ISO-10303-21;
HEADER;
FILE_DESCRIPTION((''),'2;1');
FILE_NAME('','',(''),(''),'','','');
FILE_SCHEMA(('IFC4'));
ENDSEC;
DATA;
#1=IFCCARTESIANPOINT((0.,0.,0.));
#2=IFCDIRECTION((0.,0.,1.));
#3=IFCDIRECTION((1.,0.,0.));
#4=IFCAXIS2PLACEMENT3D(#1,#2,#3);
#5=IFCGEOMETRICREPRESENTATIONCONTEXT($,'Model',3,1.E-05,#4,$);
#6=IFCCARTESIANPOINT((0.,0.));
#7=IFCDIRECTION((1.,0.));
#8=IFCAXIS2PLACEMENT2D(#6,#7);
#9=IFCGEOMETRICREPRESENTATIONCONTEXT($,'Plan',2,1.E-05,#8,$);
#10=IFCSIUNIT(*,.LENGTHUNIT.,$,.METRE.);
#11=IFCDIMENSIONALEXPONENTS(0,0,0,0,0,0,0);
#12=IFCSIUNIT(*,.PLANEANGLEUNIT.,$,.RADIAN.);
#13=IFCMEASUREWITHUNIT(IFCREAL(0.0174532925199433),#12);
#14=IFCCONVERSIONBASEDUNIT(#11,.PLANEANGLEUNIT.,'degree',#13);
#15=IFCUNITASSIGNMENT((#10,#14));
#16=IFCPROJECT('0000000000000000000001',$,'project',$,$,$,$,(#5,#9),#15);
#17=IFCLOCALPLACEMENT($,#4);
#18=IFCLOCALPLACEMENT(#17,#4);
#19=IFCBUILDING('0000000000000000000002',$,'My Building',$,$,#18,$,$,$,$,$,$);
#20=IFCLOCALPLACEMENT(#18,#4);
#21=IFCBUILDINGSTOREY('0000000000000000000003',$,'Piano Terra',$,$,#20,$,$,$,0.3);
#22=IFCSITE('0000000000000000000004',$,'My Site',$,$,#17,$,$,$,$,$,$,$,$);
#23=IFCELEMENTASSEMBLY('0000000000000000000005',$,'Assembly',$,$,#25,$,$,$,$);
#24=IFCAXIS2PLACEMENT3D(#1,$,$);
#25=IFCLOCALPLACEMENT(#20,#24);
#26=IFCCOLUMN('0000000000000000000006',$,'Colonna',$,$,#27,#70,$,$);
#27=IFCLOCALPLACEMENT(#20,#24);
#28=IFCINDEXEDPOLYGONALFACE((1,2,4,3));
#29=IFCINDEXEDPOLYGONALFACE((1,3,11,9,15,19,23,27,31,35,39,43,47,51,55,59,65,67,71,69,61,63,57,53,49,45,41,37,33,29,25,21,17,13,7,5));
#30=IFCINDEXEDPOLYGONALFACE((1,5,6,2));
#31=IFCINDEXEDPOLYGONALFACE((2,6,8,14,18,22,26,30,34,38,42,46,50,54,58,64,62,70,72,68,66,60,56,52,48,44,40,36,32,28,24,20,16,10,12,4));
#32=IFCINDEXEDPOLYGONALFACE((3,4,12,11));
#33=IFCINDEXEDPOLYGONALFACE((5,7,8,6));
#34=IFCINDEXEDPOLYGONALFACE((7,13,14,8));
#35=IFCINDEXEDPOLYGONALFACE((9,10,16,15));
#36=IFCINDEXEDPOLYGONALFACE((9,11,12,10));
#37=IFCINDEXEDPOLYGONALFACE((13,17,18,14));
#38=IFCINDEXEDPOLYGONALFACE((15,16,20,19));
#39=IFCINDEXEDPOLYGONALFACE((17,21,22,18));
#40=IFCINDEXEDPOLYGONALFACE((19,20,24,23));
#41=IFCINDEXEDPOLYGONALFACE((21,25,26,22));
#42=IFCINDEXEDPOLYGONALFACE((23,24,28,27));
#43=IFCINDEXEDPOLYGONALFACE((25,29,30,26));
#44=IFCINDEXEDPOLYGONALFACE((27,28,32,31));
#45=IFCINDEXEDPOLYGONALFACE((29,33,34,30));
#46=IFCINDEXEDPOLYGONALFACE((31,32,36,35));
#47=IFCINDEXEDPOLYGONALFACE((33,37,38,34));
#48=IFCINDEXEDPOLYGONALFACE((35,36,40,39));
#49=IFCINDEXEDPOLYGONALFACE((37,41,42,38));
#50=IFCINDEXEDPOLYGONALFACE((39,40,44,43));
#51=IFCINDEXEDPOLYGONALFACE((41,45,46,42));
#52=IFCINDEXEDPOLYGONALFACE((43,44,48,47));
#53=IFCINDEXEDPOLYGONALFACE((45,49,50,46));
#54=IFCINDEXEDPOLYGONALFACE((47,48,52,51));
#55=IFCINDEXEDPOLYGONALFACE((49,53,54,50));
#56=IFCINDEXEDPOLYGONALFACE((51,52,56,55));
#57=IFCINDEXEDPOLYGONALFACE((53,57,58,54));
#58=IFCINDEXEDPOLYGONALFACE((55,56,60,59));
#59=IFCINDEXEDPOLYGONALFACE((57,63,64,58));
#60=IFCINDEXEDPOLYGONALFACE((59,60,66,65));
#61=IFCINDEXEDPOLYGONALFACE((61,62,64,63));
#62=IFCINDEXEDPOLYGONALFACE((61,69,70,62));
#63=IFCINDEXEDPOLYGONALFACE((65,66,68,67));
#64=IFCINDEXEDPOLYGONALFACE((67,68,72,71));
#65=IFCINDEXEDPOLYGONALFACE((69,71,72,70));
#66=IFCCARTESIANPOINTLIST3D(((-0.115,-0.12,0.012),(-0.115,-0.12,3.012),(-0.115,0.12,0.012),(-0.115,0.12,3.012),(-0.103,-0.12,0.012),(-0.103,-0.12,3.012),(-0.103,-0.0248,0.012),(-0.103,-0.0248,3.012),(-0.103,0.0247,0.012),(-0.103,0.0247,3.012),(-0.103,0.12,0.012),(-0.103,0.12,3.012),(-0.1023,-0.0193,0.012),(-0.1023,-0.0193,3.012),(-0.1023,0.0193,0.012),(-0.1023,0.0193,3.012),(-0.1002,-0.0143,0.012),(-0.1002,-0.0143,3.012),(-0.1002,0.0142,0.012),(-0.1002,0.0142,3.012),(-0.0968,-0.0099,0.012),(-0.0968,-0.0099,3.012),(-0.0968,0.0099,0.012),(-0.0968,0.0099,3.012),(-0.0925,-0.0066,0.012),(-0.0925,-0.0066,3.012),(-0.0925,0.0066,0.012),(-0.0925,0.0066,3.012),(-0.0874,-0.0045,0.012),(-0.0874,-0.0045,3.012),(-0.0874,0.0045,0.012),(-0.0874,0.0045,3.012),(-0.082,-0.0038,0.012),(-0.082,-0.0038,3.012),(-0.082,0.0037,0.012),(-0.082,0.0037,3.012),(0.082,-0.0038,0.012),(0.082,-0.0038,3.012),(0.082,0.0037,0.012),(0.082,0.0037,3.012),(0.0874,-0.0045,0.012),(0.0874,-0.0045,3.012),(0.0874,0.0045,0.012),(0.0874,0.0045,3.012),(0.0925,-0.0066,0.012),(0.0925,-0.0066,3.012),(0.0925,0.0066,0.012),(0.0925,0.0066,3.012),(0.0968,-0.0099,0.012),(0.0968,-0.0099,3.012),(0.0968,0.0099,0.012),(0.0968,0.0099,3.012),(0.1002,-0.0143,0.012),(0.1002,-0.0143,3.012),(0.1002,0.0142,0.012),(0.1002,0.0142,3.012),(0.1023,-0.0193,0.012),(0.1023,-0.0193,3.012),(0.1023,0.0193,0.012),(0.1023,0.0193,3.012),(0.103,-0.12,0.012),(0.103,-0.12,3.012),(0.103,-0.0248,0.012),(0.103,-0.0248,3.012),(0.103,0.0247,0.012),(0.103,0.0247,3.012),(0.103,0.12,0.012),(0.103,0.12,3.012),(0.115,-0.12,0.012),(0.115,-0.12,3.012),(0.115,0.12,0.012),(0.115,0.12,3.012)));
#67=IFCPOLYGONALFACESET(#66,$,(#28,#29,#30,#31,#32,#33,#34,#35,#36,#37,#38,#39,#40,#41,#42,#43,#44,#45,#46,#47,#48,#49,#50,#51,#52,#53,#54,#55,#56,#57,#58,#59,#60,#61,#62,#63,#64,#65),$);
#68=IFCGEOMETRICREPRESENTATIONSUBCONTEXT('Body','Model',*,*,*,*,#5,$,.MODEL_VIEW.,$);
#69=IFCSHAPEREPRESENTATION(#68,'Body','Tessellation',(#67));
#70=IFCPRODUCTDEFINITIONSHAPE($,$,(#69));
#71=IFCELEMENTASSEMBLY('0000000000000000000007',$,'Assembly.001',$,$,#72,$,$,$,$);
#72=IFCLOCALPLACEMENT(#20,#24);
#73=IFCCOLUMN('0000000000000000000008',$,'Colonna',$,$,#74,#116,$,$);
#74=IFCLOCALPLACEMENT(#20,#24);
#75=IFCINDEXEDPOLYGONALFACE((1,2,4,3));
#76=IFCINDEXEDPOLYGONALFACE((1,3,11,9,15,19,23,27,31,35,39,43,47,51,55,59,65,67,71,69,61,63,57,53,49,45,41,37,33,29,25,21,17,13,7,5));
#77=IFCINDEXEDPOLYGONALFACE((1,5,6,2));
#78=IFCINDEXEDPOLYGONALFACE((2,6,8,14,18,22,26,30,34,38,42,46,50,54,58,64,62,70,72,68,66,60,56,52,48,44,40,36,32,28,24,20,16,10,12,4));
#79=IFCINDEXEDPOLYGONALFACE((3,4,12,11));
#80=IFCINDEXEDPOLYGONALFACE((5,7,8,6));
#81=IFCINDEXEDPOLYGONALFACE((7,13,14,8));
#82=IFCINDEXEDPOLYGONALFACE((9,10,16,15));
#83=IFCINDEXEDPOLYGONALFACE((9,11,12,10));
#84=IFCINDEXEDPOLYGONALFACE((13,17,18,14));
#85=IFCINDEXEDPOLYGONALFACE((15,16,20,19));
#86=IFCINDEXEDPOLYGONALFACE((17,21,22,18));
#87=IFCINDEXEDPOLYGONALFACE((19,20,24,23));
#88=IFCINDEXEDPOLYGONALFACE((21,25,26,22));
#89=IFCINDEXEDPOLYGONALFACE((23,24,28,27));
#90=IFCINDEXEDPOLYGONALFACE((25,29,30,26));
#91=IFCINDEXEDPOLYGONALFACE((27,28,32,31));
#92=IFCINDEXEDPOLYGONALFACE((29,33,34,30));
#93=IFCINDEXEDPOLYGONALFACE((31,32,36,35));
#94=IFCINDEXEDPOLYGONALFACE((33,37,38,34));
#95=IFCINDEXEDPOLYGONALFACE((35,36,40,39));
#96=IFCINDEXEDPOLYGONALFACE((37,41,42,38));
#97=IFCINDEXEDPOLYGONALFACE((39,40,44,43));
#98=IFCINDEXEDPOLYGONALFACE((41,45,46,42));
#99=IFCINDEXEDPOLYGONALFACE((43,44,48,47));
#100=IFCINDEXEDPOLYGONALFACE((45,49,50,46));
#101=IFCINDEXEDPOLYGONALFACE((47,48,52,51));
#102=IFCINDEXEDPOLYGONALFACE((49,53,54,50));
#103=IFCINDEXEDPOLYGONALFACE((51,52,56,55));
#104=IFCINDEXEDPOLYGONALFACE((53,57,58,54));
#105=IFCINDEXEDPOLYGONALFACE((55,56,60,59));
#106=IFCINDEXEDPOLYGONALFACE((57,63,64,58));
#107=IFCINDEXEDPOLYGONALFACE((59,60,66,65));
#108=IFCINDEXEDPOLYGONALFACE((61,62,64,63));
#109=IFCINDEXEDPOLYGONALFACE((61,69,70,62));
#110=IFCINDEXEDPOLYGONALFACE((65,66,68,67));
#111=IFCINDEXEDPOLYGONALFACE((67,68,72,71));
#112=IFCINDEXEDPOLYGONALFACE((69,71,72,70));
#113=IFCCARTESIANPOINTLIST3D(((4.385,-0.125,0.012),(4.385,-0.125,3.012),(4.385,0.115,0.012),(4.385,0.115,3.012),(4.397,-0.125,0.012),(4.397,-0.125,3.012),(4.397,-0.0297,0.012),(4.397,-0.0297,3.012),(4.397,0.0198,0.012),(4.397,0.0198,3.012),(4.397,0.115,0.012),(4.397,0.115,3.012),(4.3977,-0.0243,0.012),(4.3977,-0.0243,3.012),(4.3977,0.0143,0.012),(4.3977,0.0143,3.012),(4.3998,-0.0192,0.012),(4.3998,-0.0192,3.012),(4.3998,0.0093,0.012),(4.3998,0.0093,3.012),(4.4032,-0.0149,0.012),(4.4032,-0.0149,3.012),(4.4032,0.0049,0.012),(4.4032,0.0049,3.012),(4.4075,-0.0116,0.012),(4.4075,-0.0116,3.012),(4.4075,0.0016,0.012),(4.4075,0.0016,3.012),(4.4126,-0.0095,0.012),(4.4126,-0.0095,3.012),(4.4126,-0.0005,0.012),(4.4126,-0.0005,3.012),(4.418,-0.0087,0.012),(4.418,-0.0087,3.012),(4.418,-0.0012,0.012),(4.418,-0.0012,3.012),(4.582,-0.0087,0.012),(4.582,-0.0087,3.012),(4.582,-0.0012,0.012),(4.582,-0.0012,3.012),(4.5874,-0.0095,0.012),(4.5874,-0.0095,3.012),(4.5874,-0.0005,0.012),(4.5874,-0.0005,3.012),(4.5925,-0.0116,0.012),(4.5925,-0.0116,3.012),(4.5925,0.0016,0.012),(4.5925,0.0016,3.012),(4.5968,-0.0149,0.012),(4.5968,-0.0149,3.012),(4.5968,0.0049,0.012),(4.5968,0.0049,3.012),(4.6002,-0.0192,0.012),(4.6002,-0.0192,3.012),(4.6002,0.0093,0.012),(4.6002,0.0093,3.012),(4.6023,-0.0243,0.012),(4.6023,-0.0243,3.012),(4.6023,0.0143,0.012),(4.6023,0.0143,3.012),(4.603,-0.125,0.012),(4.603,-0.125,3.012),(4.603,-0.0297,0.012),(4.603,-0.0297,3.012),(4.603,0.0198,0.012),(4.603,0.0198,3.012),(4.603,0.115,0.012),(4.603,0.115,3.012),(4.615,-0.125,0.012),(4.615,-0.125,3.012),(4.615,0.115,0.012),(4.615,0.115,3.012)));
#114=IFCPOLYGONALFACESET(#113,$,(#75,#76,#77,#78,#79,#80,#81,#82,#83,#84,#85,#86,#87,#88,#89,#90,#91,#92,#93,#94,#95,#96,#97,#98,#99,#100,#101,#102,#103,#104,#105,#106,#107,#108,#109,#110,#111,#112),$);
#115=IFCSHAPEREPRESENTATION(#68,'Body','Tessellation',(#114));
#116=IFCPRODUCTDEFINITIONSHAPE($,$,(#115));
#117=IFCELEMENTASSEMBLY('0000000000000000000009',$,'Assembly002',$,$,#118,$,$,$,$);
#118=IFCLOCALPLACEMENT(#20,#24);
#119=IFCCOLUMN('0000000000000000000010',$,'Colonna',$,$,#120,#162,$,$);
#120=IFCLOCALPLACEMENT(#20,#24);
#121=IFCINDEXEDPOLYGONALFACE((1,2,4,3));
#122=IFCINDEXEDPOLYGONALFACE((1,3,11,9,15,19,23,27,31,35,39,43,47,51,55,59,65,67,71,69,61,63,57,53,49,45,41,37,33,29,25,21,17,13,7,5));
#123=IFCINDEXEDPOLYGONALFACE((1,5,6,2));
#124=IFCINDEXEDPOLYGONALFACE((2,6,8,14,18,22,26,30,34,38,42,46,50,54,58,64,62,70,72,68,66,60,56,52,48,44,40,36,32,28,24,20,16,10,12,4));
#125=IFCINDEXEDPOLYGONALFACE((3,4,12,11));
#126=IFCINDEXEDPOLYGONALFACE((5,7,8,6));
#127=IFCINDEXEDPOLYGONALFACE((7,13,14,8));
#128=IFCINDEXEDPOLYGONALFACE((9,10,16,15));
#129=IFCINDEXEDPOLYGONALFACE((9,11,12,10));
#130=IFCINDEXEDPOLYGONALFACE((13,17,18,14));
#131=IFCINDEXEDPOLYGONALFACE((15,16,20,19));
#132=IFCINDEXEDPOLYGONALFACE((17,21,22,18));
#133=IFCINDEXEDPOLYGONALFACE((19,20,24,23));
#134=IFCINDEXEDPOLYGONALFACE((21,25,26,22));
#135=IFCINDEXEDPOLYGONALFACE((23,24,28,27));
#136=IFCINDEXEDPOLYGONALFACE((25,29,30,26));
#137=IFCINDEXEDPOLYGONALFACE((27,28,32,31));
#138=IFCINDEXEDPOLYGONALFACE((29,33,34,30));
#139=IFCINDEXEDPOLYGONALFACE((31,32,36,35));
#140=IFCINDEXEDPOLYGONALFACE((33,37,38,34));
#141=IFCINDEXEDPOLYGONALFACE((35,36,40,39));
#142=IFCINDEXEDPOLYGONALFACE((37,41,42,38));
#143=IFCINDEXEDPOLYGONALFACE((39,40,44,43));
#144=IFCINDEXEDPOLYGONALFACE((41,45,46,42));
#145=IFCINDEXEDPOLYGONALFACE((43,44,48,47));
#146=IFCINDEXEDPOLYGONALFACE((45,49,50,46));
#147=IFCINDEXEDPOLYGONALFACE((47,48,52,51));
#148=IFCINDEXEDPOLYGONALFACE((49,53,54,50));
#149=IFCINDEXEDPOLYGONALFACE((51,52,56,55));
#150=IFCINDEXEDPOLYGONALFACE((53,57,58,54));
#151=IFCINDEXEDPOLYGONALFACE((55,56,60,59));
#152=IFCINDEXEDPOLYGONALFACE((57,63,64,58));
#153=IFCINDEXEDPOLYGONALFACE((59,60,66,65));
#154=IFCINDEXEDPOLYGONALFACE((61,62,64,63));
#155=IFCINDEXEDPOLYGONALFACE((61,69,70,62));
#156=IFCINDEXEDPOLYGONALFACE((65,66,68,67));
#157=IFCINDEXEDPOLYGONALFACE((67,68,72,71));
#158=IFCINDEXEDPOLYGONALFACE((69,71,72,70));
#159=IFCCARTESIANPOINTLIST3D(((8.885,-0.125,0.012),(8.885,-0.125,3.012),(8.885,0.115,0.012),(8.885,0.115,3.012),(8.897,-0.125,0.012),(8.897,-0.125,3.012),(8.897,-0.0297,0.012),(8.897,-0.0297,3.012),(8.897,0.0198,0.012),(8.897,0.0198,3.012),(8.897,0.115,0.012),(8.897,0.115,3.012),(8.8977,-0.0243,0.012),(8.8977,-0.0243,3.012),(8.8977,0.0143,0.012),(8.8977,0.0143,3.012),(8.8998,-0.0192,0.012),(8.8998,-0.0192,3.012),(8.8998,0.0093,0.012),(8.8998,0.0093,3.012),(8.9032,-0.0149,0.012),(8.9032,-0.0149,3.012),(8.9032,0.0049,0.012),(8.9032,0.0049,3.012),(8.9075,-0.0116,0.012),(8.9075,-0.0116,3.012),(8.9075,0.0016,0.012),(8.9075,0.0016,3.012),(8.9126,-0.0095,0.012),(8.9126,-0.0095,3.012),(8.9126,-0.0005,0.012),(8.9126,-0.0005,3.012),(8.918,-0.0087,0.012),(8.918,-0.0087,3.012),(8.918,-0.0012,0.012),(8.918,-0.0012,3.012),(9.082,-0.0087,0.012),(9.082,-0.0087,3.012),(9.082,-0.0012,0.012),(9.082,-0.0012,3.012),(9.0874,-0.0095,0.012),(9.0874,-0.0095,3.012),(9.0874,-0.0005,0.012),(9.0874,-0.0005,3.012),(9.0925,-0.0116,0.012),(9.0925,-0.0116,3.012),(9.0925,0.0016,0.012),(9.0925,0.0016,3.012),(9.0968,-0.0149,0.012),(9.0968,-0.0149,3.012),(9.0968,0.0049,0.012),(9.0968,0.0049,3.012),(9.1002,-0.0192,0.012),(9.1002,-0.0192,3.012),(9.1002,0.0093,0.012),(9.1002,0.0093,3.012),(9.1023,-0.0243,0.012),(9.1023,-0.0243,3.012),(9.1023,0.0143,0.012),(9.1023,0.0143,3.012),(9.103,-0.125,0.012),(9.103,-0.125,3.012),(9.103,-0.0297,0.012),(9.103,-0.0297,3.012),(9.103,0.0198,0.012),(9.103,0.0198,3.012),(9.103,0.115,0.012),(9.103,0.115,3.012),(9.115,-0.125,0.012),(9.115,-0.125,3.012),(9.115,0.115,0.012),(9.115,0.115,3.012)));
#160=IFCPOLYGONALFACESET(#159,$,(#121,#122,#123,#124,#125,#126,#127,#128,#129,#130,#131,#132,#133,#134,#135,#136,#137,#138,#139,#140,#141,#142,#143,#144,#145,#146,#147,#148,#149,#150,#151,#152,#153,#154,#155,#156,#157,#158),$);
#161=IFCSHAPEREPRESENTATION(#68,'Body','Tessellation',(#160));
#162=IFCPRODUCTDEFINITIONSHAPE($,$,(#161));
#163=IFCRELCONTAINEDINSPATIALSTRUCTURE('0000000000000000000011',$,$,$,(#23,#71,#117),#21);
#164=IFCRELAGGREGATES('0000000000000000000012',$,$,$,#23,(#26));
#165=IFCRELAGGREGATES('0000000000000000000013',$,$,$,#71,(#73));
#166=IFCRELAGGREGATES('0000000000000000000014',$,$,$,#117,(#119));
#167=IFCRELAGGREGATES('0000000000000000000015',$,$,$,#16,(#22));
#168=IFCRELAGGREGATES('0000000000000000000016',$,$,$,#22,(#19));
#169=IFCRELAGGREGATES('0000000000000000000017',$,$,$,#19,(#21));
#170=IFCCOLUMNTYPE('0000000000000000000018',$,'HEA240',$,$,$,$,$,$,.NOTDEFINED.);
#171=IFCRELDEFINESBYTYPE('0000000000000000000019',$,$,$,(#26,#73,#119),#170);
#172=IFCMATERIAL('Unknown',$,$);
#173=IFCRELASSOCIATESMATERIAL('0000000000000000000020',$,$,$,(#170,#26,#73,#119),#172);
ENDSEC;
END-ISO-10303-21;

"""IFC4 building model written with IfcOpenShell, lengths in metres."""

from ifc_helpers import new_model, entity, si_unit, converted_unit, frame, origin_with_axes, origin_2d_with_axis, place, context, subcontext, project, spatial, i_section, extrude, material, material_profile, profile_set, profile_usage, type_object, element, aggregate, save


model = new_model("IFC4")

# Units and contexts
model_context = context("Model", 3, precision=1e-05, world=origin_with_axes())
plan_context = context("Plan", 2, precision=1e-05, world=origin_2d_with_axis())
body_context = subcontext(model_context, "Body", "Model", "MODEL_VIEW")
ifc_project = project(units=[si_unit("LENGTHUNIT", "METRE"), converted_unit("PLANEANGLEUNIT", "degree", entity("IfcReal", 0.0174532925199433), si_unit("PLANEANGLEUNIT", "RADIAN"), dimensions=[0, 0, 0, 0, 0, 0, 0])], contexts=[model_context, plan_context])

# Site, building, storey
site_placement = place(None, origin_with_axes())
site = spatial("IfcSite", under=ifc_project, at=site_placement, Name="My Site")
building_placement = place(site_placement, origin_with_axes())
building = spatial("IfcBuilding", under=site, at=building_placement, Name="My Building")
storey_placement = place(building_placement, origin_with_axes())
storey = spatial("IfcBuildingStorey", under=building, at=storey_placement, Name="Piano Terra", Elevation=0.3)

# Element assemblies, columns
assembly_1_placement = place(storey_placement, origin_with_axes())
assembly_1 = element("IfcElementAssembly", 1, at=assembly_1_placement, inside=storey, Name="Assembly")
ifc_material_1 = material(Name="Unknown")
ifc_material_profile = material_profile(ifc_material_1, i_section(OverallWidth=0.24, OverallDepth=0.23, WebThickness=0.0075, FlangeThickness=0.012, FilletRadius=0.021))
ifc_profile_set = profile_set([ifc_material_profile])
ifc_profile_usage_1 = profile_usage(ifc_profile_set, cardinal=5)
column_type = type_object("IfcColumnType", Name="HEA240", PredefinedType="NOTDEFINED", material=ifc_profile_set)
column_1_placement = place(assembly_1_placement, frame((0.0, 0.0, 0.012), z_axis=(0.0, 0.0, 1.0), x_axis=(0.0, 1.0, 0.0)))
column_1 = element("IfcColumn", 2, at=column_1_placement, type_object=column_type, material=ifc_profile_usage_1, Name="Colonna", context=body_context, shape_type="SweptSolid", body=[
    extrude(i_section(OverallWidth=0.24, OverallDepth=0.23, WebThickness=0.0075, FlangeThickness=0.012, FilletRadius=0.021), origin_with_axes(), (0.0, 0.0, 1.0), 3.0),
])
assembly_2_placement = place(storey_placement, frame((4.5, 0.0, 0.0), z_axis=(0.0, 0.0, 1.0), x_axis=(1.0, 0.0, 0.0)))
assembly_2 = element("IfcElementAssembly", 3, at=assembly_2_placement, inside=storey, Name="Assembly.001")
ifc_profile_usage_2 = profile_usage(ifc_profile_set)
column_2_placement = place(assembly_2_placement, frame((0.0, -0.005, 0.012), z_axis=(0.0, 0.0, 1.0), x_axis=(0.0, 1.0, 0.0)))
column_2 = element("IfcColumn", 4, at=column_2_placement, type_object=column_type, material=ifc_profile_usage_2, Name="Colonna", context=body_context, shape_type="SweptSolid", body=[
    extrude(i_section(OverallWidth=0.24, OverallDepth=0.23, WebThickness=0.0075, FlangeThickness=0.012, FilletRadius=0.021), origin_with_axes(), (0.0, 0.0, 1.0), 3.0),
])
assembly_3_placement = place(storey_placement, frame((9.0, 0.0, 0.0), z_axis=(0.0, 0.0, 1.0), x_axis=(1.0, 0.0, 0.0)))
assembly_3 = element("IfcElementAssembly", 5, at=assembly_3_placement, inside=storey, Name="Assembly002")
ifc_profile_usage_3 = profile_usage(ifc_profile_set)
column_3_placement = place(assembly_3_placement, frame((0.0, -0.005, 0.012), z_axis=(0.0, 0.0, 1.0), x_axis=(0.0, 1.0, 0.0)))
column_3 = element("IfcColumn", 6, at=column_3_placement, type_object=column_type, material=ifc_profile_usage_3, Name="Colonna", context=body_context, shape_type="SweptSolid", body=[
    extrude(i_section(OverallWidth=0.24, OverallDepth=0.23, WebThickness=0.0075, FlangeThickness=0.012, FilletRadius=0.021), origin_with_axes(), (0.0, 0.0, 1.0), 3.0),
])

aggregate(assembly_1, [column_1])
aggregate(assembly_2, [column_2])
aggregate(assembly_3, [column_3])

save(model, "model.ifc")
